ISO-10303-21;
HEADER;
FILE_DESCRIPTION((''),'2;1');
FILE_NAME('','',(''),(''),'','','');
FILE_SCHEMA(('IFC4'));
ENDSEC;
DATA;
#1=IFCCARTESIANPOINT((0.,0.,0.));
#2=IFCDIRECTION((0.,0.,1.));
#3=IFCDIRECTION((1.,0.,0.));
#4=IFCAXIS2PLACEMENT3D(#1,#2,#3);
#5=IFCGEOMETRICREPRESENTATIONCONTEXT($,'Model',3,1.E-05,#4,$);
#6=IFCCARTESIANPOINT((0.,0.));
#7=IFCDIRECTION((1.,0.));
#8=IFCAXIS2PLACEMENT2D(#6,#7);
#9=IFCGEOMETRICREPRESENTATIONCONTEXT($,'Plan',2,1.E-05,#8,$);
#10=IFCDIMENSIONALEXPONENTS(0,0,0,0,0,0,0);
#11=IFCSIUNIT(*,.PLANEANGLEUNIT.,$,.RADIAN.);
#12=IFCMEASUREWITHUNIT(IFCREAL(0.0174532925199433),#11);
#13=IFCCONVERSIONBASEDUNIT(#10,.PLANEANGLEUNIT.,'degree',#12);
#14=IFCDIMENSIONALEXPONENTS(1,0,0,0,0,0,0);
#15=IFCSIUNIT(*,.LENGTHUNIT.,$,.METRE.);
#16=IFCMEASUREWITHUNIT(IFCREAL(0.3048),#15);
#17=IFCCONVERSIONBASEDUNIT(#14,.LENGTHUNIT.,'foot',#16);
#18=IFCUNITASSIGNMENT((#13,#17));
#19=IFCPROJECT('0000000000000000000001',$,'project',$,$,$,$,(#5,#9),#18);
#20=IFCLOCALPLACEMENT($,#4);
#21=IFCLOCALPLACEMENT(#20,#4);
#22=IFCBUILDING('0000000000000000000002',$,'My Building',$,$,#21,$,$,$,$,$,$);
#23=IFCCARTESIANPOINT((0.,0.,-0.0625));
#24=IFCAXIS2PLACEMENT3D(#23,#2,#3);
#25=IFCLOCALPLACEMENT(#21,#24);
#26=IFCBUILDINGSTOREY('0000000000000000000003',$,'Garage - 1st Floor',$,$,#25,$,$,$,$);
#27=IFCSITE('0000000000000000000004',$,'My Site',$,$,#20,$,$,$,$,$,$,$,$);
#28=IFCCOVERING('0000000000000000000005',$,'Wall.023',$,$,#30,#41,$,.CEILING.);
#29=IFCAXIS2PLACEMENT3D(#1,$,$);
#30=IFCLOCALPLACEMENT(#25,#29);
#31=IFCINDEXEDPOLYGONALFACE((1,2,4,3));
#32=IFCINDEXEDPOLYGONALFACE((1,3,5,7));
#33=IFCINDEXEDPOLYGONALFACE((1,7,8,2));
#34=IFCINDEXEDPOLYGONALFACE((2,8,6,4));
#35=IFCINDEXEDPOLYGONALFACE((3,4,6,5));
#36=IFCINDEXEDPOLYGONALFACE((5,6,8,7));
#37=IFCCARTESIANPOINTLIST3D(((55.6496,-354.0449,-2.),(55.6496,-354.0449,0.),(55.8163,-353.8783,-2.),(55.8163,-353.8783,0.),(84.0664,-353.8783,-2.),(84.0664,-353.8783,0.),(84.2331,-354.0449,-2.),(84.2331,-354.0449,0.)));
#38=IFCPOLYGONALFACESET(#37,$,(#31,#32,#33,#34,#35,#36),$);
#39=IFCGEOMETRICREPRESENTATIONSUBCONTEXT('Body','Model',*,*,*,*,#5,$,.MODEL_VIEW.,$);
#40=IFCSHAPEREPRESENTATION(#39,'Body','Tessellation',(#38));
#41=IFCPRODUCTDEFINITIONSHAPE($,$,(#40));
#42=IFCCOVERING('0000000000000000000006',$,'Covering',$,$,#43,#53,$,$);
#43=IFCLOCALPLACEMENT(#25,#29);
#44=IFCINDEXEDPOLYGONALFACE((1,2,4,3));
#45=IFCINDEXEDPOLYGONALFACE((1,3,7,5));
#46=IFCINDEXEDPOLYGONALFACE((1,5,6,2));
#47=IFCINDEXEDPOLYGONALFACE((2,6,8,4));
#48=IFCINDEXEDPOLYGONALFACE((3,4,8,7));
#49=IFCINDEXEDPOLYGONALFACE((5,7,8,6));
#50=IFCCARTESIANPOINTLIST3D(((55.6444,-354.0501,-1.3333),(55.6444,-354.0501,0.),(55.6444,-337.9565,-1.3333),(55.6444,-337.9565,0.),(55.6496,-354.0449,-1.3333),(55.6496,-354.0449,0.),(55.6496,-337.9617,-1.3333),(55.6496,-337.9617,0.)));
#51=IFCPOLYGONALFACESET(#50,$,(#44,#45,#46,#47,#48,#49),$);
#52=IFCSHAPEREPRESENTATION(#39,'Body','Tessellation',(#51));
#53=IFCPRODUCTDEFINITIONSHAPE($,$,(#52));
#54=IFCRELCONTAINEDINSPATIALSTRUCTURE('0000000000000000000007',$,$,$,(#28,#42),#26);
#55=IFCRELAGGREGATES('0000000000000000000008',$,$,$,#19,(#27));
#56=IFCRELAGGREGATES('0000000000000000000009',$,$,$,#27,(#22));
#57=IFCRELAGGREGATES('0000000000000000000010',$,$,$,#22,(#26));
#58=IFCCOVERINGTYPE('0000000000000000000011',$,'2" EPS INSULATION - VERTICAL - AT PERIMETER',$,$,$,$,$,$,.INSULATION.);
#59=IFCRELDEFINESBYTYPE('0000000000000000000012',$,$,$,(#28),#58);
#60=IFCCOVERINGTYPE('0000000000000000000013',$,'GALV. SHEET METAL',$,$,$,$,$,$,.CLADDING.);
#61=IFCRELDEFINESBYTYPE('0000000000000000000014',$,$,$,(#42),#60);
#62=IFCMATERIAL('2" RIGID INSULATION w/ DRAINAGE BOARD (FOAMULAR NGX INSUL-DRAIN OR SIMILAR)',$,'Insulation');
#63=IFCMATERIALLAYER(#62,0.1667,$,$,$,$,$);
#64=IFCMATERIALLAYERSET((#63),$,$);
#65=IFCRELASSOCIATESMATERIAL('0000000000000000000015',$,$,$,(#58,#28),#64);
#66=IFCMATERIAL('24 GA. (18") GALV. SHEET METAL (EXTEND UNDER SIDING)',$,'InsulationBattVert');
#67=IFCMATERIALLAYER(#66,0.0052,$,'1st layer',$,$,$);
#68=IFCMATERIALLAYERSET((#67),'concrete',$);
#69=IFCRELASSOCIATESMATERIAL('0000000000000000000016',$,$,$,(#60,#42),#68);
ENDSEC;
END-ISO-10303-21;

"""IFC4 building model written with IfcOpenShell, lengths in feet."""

from ifc_helpers import new_model, entity, si_unit, converted_unit, frame, origin_with_axes, origin_2d_with_axis, place, context, subcontext, project, spatial, line, indexed_curve, outline, extrude, material, layer, layer_set, layer_usage, type_object, element, save


model = new_model("IFC4")

# Units and contexts
model_context = context("Model", 3, precision=1e-05, world=origin_with_axes())
plan_context = context("Plan", 2, precision=1e-05, world=origin_2d_with_axis())
body_context = subcontext(model_context, "Body", "Model", "MODEL_VIEW")
ifc_project = project(units=[converted_unit("PLANEANGLEUNIT", "degree", entity("IfcReal", 0.0174532925199433), si_unit("PLANEANGLEUNIT", "RADIAN"), dimensions=[0, 0, 0, 0, 0, 0, 0]), converted_unit("LENGTHUNIT", "foot", entity("IfcReal", 0.3048), si_unit("LENGTHUNIT", "METRE"), dimensions=[1, 0, 0, 0, 0, 0, 0])], contexts=[model_context, plan_context])

# Site, building, storey
site_placement = place(None, origin_with_axes())
site = spatial("IfcSite", under=ifc_project, at=site_placement, Name="My Site")
building_placement = place(site_placement, origin_with_axes())
building = spatial("IfcBuilding", under=site, at=building_placement, Name="My Building")
storey_placement = place(building_placement, frame((0.0, 0.0, -0.0625), z_axis=(0.0, 0.0, 1.0), x_axis=(1.0, 0.0, 0.0)))
storey = spatial("IfcBuildingStorey", under=building, at=storey_placement, Name="Garage - 1st Floor")

# Coverings
ifc_material_1 = material(Name="2\" RIGID INSULATION w/ DRAINAGE BOARD (FOAMULAR NGX INSUL-DRAIN OR SIMILAR)", Category="Insulation")
ifc_layer_1 = layer(ifc_material_1, 0.1667)
ifc_layer_set_1 = layer_set([ifc_layer_1])
ifc_layer_usage_1 = layer_usage(ifc_layer_set_1, "AXIS2", "POSITIVE", 0.0)
covering_type_1 = type_object("IfcCoveringType", Name="2\" EPS INSULATION - VERTICAL - AT PERIMETER", PredefinedType="INSULATION", material=ifc_layer_set_1)
covering_1_placement = place(storey_placement, frame((55.6496, -354.0449, -2.0), z_axis=(0.0, 0.0, 1.0), x_axis=(1.0, 0.0, 0.0)))
element("IfcCovering", 1, at=covering_1_placement, inside=storey, type_object=covering_type_1, material=ifc_layer_usage_1, Name="Wall.023", PredefinedType="CEILING", context=body_context, shape_type="SweptSolid", body=[
    extrude(outline(indexed_curve([(0.0, 0.0), (0.1667, 0.1667), (28.4168, 0.1667), (28.5835, 0.0)], segments=[line(1, 2, 3, 4, 1)])), origin_with_axes(), (0.0, 0.0, 1.0), 2.0),
])
ifc_material_2 = material(Name="24 GA. (18\") GALV. SHEET METAL (EXTEND UNDER SIDING)", Category="InsulationBattVert")
ifc_layer_2 = layer(ifc_material_2, 0.0052, Name="1st layer")
ifc_layer_set_2 = layer_set([ifc_layer_2], Name="concrete")
ifc_layer_usage_2 = layer_usage(ifc_layer_set_2, "AXIS2", "POSITIVE", 0.0)
covering_type_2 = type_object("IfcCoveringType", Name="GALV. SHEET METAL", PredefinedType="CLADDING", material=ifc_layer_set_2)
covering_2_placement = place(storey_placement, frame((55.6496, -354.0449, -1.3333), z_axis=(0.0, 0.0, 1.0), x_axis=(0.0, 1.0, 0.0)))
element("IfcCovering", 2, at=covering_2_placement, inside=storey, type_object=covering_type_2, material=ifc_layer_usage_2, Name="Covering", context=body_context, shape_type="SweptSolid", body=[
    extrude(outline(indexed_curve([(0.0, 0.0), (-0.0052, 0.0052), (16.0885, 0.0052), (16.0833, 0.0)], segments=[line(1, 2, 3, 4, 1)])), origin_with_axes(), (0.0, 0.0, 1.0), 1.3333),
])

save(model, "model.ifc")
